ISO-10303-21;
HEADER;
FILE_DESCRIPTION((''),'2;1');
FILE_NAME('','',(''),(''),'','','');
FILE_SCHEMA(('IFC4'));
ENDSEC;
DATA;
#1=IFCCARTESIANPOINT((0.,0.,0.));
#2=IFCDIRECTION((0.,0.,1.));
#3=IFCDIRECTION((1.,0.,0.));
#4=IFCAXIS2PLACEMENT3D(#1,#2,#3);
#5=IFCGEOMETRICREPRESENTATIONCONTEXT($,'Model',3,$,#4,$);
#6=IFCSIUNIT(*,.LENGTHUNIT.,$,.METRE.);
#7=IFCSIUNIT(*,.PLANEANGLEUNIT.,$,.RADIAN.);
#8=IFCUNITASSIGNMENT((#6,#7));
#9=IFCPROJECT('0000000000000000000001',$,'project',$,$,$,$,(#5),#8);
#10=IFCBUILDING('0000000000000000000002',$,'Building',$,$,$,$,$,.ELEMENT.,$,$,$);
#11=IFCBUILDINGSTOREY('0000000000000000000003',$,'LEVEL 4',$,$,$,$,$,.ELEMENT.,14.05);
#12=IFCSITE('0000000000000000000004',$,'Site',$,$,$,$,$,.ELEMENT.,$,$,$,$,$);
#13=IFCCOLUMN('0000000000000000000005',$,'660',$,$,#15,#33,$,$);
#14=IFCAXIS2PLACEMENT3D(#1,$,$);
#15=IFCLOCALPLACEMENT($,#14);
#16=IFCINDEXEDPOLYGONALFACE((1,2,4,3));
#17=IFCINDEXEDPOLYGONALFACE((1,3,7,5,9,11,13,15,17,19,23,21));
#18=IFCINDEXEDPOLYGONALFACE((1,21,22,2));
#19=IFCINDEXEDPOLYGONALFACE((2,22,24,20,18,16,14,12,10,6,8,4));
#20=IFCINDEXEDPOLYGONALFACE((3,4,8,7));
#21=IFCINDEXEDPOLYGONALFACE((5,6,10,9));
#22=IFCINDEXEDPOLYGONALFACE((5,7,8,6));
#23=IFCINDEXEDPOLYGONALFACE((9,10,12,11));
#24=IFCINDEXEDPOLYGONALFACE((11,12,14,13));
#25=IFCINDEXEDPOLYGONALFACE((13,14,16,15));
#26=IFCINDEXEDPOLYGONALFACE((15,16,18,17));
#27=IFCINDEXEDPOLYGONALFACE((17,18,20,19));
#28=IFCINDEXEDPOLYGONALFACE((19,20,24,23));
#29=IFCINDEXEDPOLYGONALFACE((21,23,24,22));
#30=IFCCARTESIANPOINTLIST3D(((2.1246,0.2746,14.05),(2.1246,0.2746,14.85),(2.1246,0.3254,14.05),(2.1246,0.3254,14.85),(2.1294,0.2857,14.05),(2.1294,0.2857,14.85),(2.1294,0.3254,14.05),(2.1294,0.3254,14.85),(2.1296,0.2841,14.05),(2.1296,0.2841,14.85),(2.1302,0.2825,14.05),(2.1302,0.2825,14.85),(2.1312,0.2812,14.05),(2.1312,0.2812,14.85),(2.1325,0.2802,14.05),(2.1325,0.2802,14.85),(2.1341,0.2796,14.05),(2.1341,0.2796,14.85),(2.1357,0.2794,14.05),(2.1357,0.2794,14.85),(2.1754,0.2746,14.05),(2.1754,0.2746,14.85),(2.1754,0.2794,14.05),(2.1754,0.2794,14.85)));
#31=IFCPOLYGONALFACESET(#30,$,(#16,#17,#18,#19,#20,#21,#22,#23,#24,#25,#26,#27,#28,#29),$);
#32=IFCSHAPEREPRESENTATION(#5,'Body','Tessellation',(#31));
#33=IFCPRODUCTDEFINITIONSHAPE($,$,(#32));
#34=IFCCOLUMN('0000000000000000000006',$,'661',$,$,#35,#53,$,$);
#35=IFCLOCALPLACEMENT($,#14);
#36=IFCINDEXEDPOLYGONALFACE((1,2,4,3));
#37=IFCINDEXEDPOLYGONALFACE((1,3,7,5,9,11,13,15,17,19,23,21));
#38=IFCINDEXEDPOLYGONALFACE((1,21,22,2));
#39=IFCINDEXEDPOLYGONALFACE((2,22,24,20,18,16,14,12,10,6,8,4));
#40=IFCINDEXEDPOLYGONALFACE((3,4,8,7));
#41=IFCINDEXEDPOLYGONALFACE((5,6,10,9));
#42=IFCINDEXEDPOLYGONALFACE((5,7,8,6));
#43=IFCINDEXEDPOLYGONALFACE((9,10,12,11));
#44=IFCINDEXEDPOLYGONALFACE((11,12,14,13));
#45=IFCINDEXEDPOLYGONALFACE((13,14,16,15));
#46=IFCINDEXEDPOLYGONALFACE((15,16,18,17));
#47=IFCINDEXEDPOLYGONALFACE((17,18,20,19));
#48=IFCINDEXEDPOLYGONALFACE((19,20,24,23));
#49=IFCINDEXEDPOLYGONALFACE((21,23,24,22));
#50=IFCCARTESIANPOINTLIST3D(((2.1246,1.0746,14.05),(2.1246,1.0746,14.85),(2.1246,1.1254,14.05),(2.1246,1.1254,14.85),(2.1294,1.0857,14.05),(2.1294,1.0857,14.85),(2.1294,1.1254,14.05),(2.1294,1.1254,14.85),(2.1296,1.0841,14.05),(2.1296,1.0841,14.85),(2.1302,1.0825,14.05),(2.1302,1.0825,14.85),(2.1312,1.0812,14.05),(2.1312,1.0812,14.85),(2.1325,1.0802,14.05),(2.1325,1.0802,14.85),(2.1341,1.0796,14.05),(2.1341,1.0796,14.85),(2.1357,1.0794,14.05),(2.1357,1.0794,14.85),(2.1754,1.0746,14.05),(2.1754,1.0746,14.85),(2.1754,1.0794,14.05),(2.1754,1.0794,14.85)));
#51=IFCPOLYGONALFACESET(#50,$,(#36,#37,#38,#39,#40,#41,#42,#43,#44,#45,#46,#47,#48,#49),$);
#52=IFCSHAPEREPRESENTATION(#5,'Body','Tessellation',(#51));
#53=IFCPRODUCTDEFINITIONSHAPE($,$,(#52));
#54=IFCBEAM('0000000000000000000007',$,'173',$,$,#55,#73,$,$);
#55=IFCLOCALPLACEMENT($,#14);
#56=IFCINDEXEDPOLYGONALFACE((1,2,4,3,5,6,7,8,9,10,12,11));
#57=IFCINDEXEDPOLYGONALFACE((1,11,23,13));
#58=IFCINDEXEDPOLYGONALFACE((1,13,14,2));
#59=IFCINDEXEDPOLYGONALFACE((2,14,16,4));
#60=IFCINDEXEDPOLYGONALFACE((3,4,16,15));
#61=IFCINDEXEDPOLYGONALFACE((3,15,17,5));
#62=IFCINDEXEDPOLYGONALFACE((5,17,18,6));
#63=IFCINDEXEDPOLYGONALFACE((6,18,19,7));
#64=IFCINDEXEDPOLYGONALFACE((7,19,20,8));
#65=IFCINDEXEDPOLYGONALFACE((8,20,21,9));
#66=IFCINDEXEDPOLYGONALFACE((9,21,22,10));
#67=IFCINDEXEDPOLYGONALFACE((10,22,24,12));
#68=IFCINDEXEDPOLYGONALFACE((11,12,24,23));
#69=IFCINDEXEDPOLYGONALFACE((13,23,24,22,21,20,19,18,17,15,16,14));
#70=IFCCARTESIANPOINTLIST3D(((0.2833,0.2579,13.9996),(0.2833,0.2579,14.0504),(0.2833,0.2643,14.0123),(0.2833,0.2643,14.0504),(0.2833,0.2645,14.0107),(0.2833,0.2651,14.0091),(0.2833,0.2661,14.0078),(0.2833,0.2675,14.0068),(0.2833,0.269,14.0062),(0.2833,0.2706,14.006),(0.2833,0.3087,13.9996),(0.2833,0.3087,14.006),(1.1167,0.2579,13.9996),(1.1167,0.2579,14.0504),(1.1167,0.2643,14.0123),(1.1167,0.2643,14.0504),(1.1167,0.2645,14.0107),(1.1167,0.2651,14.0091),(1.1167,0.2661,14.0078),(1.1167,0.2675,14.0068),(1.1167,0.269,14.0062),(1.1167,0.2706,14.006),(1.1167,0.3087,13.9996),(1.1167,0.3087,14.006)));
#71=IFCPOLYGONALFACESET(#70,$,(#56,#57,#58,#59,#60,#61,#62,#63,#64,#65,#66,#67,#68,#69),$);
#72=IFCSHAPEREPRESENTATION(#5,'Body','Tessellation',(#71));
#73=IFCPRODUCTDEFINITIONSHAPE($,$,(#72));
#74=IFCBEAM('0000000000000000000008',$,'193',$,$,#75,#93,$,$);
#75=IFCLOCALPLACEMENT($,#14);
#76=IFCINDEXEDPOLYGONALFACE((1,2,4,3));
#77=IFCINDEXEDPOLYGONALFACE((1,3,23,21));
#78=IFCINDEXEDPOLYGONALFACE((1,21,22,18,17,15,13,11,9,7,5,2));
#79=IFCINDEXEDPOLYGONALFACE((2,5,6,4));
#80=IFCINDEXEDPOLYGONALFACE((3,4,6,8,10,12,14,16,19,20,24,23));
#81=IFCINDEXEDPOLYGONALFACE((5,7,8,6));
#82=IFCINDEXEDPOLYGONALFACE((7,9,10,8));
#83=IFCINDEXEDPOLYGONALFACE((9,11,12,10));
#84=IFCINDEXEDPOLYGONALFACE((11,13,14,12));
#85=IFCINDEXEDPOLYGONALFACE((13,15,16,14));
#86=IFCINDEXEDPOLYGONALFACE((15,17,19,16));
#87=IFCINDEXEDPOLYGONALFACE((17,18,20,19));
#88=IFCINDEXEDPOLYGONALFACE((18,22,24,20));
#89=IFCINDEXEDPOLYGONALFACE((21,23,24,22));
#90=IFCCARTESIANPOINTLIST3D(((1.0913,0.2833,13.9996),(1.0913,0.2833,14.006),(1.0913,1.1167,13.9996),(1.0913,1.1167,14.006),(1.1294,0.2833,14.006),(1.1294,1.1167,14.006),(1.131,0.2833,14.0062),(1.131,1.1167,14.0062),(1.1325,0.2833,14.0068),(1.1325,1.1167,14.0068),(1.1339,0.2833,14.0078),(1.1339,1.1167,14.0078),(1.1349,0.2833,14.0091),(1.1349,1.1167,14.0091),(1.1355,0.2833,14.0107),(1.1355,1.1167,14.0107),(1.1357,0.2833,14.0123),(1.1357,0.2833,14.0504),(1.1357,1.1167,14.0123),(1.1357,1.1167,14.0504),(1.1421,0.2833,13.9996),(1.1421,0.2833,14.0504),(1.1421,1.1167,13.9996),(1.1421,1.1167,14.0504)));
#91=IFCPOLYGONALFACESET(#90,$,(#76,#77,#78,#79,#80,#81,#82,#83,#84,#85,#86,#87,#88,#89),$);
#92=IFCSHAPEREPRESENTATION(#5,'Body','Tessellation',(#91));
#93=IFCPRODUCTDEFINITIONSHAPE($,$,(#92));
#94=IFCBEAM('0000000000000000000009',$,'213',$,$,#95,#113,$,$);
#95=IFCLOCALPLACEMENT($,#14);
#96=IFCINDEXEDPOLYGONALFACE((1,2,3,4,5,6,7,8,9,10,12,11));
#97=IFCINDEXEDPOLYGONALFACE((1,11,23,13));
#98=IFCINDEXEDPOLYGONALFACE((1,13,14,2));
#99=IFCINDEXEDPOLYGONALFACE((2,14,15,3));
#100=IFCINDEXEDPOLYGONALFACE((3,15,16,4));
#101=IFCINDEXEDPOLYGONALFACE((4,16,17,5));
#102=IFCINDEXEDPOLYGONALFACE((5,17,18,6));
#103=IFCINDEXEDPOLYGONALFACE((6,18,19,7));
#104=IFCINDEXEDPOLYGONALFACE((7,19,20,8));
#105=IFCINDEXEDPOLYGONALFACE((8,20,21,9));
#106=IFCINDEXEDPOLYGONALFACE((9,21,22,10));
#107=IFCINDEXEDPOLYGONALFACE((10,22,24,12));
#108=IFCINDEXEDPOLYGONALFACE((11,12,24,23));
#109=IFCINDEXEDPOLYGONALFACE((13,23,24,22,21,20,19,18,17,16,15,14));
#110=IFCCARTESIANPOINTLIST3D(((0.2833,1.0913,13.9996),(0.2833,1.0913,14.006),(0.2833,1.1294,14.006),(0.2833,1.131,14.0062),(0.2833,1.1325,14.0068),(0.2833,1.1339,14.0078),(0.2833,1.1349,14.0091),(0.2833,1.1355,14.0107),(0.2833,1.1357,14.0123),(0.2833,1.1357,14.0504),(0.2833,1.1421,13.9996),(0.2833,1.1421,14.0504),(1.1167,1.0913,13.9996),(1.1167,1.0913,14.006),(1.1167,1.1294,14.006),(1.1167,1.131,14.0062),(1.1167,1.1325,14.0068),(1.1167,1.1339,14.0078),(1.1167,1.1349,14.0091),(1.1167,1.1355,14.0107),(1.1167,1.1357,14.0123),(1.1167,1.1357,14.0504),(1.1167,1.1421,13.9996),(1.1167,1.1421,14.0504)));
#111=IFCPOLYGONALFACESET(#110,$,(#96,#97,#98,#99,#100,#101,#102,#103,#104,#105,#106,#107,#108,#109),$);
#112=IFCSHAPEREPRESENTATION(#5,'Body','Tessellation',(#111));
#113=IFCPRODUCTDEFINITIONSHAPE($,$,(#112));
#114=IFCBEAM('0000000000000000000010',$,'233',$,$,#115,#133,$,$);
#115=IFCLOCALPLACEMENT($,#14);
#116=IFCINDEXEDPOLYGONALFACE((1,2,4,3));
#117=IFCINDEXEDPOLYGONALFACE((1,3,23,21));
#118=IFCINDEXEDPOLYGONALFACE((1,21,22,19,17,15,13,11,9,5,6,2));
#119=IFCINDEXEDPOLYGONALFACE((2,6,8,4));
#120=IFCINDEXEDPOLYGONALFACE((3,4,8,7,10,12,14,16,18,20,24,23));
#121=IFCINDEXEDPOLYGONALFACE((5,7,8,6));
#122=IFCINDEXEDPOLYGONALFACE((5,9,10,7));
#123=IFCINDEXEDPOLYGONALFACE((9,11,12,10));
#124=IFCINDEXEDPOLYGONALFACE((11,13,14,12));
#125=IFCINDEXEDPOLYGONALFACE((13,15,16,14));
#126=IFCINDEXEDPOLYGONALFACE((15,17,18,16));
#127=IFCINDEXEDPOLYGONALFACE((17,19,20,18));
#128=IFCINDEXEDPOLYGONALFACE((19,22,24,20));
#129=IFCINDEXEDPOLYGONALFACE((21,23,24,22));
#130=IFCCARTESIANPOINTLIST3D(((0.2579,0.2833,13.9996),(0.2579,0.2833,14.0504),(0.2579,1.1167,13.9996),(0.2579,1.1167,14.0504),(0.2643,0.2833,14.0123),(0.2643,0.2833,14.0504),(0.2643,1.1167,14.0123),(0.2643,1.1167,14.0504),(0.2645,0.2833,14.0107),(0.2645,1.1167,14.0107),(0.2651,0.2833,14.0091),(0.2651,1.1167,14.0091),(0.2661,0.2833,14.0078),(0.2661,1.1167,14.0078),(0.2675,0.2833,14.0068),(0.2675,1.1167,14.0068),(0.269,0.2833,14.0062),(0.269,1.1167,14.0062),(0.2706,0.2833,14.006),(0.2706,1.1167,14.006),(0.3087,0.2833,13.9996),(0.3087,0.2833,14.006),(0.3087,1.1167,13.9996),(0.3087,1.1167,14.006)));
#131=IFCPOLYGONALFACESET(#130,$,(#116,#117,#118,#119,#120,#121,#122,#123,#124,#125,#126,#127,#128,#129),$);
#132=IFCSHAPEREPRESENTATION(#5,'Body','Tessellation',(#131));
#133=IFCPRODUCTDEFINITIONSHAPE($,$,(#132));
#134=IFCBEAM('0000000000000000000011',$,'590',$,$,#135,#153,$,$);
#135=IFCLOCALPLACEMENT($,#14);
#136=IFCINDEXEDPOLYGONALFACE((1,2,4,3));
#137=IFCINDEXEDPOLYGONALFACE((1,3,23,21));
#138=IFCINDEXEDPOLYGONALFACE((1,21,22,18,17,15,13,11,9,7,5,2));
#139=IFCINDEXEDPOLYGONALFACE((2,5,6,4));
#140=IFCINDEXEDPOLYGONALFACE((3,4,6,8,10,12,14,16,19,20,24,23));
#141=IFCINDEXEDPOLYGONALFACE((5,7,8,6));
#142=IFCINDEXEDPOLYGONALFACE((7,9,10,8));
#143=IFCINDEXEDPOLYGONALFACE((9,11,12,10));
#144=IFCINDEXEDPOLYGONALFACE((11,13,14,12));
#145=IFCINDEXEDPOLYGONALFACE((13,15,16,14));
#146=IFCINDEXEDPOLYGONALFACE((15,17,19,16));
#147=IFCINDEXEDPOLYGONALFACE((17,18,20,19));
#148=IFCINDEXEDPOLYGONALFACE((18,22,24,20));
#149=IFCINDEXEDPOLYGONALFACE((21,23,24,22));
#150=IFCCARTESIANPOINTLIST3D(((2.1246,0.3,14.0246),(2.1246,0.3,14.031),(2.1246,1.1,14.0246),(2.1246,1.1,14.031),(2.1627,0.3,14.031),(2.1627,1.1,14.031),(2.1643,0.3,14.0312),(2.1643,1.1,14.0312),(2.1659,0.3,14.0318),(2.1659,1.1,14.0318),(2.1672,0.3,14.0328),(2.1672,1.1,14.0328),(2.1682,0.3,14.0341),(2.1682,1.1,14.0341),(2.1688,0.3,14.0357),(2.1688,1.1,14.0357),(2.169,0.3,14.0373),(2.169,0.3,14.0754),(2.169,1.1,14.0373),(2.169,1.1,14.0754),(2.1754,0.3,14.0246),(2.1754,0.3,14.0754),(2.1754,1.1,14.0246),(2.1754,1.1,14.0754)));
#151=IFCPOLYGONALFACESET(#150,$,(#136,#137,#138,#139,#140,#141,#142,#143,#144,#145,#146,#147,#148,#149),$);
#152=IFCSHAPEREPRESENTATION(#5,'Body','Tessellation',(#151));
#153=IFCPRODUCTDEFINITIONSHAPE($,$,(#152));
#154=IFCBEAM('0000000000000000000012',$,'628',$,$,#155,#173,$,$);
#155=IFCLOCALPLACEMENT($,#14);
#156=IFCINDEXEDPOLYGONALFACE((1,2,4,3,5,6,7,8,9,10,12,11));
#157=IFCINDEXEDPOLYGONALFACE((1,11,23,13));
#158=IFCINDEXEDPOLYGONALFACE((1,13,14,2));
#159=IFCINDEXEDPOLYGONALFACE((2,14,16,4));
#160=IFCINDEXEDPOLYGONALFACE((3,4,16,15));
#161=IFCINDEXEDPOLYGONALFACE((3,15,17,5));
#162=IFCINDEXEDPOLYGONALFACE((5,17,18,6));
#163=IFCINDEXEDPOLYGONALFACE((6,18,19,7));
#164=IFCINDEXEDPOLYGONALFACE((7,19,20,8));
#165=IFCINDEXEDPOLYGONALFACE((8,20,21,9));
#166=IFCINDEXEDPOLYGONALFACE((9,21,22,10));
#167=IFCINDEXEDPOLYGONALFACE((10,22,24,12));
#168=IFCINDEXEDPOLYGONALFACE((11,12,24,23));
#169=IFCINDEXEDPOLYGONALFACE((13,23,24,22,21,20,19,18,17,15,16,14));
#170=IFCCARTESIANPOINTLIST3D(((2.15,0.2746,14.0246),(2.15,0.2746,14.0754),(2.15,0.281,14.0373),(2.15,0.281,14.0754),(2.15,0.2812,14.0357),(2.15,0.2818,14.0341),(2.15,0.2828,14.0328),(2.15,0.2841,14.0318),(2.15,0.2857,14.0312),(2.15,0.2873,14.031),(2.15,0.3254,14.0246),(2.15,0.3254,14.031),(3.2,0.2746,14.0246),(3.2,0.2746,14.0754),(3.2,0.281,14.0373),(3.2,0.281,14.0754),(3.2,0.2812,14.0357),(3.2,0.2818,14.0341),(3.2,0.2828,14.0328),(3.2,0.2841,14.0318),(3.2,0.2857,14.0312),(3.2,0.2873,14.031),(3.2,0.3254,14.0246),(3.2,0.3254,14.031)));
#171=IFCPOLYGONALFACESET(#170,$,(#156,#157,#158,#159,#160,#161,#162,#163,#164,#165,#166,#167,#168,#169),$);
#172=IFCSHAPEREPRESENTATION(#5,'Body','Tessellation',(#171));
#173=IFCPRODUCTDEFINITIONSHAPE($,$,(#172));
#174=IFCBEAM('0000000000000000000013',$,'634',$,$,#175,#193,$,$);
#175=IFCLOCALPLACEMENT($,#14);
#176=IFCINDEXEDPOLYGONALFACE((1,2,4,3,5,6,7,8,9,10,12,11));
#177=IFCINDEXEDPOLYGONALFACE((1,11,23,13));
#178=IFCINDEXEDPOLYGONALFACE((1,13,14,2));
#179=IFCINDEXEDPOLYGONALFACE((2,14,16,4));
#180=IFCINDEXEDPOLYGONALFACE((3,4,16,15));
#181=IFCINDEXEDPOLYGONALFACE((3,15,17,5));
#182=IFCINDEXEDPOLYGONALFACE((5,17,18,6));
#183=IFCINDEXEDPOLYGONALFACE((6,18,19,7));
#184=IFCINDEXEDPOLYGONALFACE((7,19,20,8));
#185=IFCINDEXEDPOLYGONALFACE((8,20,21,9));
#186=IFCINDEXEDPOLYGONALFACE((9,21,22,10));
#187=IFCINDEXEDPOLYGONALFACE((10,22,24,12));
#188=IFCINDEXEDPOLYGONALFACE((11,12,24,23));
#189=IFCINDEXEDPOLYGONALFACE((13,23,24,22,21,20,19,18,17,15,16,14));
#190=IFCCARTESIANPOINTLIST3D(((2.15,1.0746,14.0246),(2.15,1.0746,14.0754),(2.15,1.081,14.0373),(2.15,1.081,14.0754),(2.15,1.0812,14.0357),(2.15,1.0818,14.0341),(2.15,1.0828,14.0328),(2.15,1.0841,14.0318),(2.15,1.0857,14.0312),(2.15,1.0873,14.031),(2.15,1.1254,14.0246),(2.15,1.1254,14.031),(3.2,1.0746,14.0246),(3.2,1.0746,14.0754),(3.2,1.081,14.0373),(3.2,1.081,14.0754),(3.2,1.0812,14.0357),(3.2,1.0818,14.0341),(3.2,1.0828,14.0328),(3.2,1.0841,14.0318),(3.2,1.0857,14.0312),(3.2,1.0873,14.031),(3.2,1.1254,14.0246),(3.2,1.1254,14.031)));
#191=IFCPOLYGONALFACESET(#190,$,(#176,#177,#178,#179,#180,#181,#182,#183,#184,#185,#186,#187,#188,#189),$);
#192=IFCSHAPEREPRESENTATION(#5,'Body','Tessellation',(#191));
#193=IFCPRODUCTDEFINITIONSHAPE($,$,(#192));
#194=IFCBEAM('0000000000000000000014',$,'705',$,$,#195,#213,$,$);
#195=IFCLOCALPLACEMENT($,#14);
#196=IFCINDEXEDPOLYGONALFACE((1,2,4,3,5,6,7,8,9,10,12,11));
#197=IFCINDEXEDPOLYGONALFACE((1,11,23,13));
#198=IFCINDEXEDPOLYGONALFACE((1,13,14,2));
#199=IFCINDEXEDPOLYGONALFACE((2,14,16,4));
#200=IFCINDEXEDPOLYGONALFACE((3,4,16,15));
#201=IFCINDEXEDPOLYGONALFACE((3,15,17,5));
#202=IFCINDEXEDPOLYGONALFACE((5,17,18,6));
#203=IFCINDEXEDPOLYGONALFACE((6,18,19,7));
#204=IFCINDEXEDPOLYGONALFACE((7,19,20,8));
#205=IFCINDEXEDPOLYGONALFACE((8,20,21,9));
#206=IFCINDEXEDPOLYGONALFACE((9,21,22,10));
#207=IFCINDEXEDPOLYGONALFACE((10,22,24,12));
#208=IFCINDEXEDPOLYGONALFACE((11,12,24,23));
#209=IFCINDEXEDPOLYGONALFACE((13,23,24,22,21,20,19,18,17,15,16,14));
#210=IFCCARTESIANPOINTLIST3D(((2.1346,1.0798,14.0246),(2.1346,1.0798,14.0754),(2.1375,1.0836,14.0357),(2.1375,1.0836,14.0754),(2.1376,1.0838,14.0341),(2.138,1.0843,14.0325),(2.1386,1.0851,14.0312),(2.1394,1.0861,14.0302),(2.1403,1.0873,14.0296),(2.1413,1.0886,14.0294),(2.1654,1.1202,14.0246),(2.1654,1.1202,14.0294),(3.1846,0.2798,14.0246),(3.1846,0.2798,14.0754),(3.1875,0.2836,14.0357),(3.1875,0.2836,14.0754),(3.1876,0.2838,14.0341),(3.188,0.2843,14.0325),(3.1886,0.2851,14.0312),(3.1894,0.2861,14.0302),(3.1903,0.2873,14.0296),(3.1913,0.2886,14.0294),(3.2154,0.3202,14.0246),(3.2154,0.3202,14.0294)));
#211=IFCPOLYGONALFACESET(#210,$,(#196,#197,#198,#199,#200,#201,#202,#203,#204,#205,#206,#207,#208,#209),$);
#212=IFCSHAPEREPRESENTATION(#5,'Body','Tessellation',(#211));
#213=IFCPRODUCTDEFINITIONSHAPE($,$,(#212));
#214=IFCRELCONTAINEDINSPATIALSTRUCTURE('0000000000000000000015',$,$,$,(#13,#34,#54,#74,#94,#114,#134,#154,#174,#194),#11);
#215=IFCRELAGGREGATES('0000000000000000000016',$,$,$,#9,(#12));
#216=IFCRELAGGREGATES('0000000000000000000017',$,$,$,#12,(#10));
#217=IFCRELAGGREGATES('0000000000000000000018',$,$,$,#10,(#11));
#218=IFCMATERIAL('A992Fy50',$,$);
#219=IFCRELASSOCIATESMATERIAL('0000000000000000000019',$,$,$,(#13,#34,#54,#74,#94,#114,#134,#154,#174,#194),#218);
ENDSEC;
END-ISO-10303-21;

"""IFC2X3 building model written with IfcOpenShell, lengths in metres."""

from ifc_helpers import new_model, si_unit, frame, origin_with_axes, origin_2d_with_axis, place, context, project, spatial, l_section, extrude, material, element, save


model = new_model("IFC2X3")

# Units and contexts
model_context = context("Model", 3, world=origin_with_axes())
ifc_project = project(units=[si_unit("LENGTHUNIT", "METRE"), si_unit("PLANEANGLEUNIT", "RADIAN")], contexts=[model_context])

# Site, building, storey
site = spatial("IfcSite", under=ifc_project, Name="Site", CompositionType="ELEMENT")
building = spatial("IfcBuilding", under=site, Name="Building", CompositionType="ELEMENT")
storey = spatial("IfcBuildingStorey", under=building, Name="LEVEL 4", CompositionType="ELEMENT", Elevation=14.05)

# Columns
ifc_material = material(Name="A992Fy50")
for number, where, z_axis, x_axis, name in (
    (1, (2.15, 0.3, 14.85), (0.0, 0.0, -1.0), (0.0, 1.0, 0.0), "660"),
    (2, (2.15, 1.1, 14.85), (0.0, 0.0, -1.0), (0.0, 1.0, 0.0), "661"),
):
    element("IfcColumn", number, at=place(None, frame(where, z_axis=z_axis, x_axis=x_axis)), inside=storey, material=ifc_material, Name=name, context=model_context, shape_type="SweptSolid", body=[
        extrude(l_section(Depth=0.0508, Width=0.0508, Thickness=0.0048, FilletRadius=0.0063, at=origin_2d_with_axis()), origin_with_axes(), (0.0, 0.0, 1.0), 0.8),
    ])

# Beams
for number, where, z_axis, x_axis, name in (
    (3, (0.2833, 0.2833, 14.025), (1.0, 0.0, 0.0), (0.0, 1.0, 0.0), "173"),
    (4, (1.1167, 0.2833, 14.025), (0.0, 1.0, 0.0), (-1.0, 0.0, 0.0), "193"),
    (5, (1.1167, 1.1167, 14.025), (-1.0, 0.0, 0.0), (0.0, -1.0, 0.0), "213"),
    (6, (0.2833, 1.1167, 14.025), (0.0, -1.0, 0.0), (1.0, 0.0, 0.0), "233"),
):
    element("IfcBeam", number, at=place(None, frame(where, z_axis=z_axis, x_axis=x_axis)), inside=storey, material=ifc_material, Name=name, context=model_context, shape_type="SweptSolid", body=[
        extrude(l_section(Depth=0.0508, Width=0.0508, Thickness=0.0063, FilletRadius=0.0063, at=origin_2d_with_axis()), origin_with_axes(), (0.0, 0.0, 1.0), 0.8333),
    ])
beam_1_placement = place(None, frame((2.15, 0.3, 14.05), z_axis=(0.0, 1.0, 0.0), x_axis=(-1.0, 0.0, 0.0)))
element("IfcBeam", 7, at=beam_1_placement, inside=storey, material=ifc_material, Name="590", context=model_context, shape_type="SweptSolid", body=[
    extrude(l_section(Depth=0.0508, Width=0.0508, Thickness=0.0063, FilletRadius=0.0063, at=origin_2d_with_axis()), origin_with_axes(), (0.0, 0.0, 1.0), 0.8),
])
for number, where, z_axis, x_axis, name in (
    (8, (2.15, 0.3, 14.05), (1.0, 0.0, 0.0), (0.0, 1.0, 0.0), "628"),
    (9, (2.15, 1.1, 14.05), (1.0, 0.0, 0.0), (0.0, 1.0, 0.0), "634"),
):
    element("IfcBeam", number, at=place(None, frame(where, z_axis=z_axis, x_axis=x_axis)), inside=storey, material=ifc_material, Name=name, context=model_context, shape_type="SweptSolid", body=[
        extrude(l_section(Depth=0.0508, Width=0.0508, Thickness=0.0063, FilletRadius=0.0063, at=origin_2d_with_axis()), origin_with_axes(), (0.0, 0.0, 1.0), 1.05),
    ])
beam_2_placement = place(None, frame((2.15, 1.1, 14.05), z_axis=(0.795432, -0.606043, 0.0), x_axis=(0.606043, 0.795432, 0.0)))
element("IfcBeam", 10, at=beam_2_placement, inside=storey, material=ifc_material, Name="705", context=model_context, shape_type="SweptSolid", body=[
    extrude(l_section(Depth=0.0508, Width=0.0508, Thickness=0.0048, FilletRadius=0.0063, at=origin_2d_with_axis()), origin_with_axes(), (0.0, 0.0, 1.0), 1.32),
])

save(model, "model.ifc")
